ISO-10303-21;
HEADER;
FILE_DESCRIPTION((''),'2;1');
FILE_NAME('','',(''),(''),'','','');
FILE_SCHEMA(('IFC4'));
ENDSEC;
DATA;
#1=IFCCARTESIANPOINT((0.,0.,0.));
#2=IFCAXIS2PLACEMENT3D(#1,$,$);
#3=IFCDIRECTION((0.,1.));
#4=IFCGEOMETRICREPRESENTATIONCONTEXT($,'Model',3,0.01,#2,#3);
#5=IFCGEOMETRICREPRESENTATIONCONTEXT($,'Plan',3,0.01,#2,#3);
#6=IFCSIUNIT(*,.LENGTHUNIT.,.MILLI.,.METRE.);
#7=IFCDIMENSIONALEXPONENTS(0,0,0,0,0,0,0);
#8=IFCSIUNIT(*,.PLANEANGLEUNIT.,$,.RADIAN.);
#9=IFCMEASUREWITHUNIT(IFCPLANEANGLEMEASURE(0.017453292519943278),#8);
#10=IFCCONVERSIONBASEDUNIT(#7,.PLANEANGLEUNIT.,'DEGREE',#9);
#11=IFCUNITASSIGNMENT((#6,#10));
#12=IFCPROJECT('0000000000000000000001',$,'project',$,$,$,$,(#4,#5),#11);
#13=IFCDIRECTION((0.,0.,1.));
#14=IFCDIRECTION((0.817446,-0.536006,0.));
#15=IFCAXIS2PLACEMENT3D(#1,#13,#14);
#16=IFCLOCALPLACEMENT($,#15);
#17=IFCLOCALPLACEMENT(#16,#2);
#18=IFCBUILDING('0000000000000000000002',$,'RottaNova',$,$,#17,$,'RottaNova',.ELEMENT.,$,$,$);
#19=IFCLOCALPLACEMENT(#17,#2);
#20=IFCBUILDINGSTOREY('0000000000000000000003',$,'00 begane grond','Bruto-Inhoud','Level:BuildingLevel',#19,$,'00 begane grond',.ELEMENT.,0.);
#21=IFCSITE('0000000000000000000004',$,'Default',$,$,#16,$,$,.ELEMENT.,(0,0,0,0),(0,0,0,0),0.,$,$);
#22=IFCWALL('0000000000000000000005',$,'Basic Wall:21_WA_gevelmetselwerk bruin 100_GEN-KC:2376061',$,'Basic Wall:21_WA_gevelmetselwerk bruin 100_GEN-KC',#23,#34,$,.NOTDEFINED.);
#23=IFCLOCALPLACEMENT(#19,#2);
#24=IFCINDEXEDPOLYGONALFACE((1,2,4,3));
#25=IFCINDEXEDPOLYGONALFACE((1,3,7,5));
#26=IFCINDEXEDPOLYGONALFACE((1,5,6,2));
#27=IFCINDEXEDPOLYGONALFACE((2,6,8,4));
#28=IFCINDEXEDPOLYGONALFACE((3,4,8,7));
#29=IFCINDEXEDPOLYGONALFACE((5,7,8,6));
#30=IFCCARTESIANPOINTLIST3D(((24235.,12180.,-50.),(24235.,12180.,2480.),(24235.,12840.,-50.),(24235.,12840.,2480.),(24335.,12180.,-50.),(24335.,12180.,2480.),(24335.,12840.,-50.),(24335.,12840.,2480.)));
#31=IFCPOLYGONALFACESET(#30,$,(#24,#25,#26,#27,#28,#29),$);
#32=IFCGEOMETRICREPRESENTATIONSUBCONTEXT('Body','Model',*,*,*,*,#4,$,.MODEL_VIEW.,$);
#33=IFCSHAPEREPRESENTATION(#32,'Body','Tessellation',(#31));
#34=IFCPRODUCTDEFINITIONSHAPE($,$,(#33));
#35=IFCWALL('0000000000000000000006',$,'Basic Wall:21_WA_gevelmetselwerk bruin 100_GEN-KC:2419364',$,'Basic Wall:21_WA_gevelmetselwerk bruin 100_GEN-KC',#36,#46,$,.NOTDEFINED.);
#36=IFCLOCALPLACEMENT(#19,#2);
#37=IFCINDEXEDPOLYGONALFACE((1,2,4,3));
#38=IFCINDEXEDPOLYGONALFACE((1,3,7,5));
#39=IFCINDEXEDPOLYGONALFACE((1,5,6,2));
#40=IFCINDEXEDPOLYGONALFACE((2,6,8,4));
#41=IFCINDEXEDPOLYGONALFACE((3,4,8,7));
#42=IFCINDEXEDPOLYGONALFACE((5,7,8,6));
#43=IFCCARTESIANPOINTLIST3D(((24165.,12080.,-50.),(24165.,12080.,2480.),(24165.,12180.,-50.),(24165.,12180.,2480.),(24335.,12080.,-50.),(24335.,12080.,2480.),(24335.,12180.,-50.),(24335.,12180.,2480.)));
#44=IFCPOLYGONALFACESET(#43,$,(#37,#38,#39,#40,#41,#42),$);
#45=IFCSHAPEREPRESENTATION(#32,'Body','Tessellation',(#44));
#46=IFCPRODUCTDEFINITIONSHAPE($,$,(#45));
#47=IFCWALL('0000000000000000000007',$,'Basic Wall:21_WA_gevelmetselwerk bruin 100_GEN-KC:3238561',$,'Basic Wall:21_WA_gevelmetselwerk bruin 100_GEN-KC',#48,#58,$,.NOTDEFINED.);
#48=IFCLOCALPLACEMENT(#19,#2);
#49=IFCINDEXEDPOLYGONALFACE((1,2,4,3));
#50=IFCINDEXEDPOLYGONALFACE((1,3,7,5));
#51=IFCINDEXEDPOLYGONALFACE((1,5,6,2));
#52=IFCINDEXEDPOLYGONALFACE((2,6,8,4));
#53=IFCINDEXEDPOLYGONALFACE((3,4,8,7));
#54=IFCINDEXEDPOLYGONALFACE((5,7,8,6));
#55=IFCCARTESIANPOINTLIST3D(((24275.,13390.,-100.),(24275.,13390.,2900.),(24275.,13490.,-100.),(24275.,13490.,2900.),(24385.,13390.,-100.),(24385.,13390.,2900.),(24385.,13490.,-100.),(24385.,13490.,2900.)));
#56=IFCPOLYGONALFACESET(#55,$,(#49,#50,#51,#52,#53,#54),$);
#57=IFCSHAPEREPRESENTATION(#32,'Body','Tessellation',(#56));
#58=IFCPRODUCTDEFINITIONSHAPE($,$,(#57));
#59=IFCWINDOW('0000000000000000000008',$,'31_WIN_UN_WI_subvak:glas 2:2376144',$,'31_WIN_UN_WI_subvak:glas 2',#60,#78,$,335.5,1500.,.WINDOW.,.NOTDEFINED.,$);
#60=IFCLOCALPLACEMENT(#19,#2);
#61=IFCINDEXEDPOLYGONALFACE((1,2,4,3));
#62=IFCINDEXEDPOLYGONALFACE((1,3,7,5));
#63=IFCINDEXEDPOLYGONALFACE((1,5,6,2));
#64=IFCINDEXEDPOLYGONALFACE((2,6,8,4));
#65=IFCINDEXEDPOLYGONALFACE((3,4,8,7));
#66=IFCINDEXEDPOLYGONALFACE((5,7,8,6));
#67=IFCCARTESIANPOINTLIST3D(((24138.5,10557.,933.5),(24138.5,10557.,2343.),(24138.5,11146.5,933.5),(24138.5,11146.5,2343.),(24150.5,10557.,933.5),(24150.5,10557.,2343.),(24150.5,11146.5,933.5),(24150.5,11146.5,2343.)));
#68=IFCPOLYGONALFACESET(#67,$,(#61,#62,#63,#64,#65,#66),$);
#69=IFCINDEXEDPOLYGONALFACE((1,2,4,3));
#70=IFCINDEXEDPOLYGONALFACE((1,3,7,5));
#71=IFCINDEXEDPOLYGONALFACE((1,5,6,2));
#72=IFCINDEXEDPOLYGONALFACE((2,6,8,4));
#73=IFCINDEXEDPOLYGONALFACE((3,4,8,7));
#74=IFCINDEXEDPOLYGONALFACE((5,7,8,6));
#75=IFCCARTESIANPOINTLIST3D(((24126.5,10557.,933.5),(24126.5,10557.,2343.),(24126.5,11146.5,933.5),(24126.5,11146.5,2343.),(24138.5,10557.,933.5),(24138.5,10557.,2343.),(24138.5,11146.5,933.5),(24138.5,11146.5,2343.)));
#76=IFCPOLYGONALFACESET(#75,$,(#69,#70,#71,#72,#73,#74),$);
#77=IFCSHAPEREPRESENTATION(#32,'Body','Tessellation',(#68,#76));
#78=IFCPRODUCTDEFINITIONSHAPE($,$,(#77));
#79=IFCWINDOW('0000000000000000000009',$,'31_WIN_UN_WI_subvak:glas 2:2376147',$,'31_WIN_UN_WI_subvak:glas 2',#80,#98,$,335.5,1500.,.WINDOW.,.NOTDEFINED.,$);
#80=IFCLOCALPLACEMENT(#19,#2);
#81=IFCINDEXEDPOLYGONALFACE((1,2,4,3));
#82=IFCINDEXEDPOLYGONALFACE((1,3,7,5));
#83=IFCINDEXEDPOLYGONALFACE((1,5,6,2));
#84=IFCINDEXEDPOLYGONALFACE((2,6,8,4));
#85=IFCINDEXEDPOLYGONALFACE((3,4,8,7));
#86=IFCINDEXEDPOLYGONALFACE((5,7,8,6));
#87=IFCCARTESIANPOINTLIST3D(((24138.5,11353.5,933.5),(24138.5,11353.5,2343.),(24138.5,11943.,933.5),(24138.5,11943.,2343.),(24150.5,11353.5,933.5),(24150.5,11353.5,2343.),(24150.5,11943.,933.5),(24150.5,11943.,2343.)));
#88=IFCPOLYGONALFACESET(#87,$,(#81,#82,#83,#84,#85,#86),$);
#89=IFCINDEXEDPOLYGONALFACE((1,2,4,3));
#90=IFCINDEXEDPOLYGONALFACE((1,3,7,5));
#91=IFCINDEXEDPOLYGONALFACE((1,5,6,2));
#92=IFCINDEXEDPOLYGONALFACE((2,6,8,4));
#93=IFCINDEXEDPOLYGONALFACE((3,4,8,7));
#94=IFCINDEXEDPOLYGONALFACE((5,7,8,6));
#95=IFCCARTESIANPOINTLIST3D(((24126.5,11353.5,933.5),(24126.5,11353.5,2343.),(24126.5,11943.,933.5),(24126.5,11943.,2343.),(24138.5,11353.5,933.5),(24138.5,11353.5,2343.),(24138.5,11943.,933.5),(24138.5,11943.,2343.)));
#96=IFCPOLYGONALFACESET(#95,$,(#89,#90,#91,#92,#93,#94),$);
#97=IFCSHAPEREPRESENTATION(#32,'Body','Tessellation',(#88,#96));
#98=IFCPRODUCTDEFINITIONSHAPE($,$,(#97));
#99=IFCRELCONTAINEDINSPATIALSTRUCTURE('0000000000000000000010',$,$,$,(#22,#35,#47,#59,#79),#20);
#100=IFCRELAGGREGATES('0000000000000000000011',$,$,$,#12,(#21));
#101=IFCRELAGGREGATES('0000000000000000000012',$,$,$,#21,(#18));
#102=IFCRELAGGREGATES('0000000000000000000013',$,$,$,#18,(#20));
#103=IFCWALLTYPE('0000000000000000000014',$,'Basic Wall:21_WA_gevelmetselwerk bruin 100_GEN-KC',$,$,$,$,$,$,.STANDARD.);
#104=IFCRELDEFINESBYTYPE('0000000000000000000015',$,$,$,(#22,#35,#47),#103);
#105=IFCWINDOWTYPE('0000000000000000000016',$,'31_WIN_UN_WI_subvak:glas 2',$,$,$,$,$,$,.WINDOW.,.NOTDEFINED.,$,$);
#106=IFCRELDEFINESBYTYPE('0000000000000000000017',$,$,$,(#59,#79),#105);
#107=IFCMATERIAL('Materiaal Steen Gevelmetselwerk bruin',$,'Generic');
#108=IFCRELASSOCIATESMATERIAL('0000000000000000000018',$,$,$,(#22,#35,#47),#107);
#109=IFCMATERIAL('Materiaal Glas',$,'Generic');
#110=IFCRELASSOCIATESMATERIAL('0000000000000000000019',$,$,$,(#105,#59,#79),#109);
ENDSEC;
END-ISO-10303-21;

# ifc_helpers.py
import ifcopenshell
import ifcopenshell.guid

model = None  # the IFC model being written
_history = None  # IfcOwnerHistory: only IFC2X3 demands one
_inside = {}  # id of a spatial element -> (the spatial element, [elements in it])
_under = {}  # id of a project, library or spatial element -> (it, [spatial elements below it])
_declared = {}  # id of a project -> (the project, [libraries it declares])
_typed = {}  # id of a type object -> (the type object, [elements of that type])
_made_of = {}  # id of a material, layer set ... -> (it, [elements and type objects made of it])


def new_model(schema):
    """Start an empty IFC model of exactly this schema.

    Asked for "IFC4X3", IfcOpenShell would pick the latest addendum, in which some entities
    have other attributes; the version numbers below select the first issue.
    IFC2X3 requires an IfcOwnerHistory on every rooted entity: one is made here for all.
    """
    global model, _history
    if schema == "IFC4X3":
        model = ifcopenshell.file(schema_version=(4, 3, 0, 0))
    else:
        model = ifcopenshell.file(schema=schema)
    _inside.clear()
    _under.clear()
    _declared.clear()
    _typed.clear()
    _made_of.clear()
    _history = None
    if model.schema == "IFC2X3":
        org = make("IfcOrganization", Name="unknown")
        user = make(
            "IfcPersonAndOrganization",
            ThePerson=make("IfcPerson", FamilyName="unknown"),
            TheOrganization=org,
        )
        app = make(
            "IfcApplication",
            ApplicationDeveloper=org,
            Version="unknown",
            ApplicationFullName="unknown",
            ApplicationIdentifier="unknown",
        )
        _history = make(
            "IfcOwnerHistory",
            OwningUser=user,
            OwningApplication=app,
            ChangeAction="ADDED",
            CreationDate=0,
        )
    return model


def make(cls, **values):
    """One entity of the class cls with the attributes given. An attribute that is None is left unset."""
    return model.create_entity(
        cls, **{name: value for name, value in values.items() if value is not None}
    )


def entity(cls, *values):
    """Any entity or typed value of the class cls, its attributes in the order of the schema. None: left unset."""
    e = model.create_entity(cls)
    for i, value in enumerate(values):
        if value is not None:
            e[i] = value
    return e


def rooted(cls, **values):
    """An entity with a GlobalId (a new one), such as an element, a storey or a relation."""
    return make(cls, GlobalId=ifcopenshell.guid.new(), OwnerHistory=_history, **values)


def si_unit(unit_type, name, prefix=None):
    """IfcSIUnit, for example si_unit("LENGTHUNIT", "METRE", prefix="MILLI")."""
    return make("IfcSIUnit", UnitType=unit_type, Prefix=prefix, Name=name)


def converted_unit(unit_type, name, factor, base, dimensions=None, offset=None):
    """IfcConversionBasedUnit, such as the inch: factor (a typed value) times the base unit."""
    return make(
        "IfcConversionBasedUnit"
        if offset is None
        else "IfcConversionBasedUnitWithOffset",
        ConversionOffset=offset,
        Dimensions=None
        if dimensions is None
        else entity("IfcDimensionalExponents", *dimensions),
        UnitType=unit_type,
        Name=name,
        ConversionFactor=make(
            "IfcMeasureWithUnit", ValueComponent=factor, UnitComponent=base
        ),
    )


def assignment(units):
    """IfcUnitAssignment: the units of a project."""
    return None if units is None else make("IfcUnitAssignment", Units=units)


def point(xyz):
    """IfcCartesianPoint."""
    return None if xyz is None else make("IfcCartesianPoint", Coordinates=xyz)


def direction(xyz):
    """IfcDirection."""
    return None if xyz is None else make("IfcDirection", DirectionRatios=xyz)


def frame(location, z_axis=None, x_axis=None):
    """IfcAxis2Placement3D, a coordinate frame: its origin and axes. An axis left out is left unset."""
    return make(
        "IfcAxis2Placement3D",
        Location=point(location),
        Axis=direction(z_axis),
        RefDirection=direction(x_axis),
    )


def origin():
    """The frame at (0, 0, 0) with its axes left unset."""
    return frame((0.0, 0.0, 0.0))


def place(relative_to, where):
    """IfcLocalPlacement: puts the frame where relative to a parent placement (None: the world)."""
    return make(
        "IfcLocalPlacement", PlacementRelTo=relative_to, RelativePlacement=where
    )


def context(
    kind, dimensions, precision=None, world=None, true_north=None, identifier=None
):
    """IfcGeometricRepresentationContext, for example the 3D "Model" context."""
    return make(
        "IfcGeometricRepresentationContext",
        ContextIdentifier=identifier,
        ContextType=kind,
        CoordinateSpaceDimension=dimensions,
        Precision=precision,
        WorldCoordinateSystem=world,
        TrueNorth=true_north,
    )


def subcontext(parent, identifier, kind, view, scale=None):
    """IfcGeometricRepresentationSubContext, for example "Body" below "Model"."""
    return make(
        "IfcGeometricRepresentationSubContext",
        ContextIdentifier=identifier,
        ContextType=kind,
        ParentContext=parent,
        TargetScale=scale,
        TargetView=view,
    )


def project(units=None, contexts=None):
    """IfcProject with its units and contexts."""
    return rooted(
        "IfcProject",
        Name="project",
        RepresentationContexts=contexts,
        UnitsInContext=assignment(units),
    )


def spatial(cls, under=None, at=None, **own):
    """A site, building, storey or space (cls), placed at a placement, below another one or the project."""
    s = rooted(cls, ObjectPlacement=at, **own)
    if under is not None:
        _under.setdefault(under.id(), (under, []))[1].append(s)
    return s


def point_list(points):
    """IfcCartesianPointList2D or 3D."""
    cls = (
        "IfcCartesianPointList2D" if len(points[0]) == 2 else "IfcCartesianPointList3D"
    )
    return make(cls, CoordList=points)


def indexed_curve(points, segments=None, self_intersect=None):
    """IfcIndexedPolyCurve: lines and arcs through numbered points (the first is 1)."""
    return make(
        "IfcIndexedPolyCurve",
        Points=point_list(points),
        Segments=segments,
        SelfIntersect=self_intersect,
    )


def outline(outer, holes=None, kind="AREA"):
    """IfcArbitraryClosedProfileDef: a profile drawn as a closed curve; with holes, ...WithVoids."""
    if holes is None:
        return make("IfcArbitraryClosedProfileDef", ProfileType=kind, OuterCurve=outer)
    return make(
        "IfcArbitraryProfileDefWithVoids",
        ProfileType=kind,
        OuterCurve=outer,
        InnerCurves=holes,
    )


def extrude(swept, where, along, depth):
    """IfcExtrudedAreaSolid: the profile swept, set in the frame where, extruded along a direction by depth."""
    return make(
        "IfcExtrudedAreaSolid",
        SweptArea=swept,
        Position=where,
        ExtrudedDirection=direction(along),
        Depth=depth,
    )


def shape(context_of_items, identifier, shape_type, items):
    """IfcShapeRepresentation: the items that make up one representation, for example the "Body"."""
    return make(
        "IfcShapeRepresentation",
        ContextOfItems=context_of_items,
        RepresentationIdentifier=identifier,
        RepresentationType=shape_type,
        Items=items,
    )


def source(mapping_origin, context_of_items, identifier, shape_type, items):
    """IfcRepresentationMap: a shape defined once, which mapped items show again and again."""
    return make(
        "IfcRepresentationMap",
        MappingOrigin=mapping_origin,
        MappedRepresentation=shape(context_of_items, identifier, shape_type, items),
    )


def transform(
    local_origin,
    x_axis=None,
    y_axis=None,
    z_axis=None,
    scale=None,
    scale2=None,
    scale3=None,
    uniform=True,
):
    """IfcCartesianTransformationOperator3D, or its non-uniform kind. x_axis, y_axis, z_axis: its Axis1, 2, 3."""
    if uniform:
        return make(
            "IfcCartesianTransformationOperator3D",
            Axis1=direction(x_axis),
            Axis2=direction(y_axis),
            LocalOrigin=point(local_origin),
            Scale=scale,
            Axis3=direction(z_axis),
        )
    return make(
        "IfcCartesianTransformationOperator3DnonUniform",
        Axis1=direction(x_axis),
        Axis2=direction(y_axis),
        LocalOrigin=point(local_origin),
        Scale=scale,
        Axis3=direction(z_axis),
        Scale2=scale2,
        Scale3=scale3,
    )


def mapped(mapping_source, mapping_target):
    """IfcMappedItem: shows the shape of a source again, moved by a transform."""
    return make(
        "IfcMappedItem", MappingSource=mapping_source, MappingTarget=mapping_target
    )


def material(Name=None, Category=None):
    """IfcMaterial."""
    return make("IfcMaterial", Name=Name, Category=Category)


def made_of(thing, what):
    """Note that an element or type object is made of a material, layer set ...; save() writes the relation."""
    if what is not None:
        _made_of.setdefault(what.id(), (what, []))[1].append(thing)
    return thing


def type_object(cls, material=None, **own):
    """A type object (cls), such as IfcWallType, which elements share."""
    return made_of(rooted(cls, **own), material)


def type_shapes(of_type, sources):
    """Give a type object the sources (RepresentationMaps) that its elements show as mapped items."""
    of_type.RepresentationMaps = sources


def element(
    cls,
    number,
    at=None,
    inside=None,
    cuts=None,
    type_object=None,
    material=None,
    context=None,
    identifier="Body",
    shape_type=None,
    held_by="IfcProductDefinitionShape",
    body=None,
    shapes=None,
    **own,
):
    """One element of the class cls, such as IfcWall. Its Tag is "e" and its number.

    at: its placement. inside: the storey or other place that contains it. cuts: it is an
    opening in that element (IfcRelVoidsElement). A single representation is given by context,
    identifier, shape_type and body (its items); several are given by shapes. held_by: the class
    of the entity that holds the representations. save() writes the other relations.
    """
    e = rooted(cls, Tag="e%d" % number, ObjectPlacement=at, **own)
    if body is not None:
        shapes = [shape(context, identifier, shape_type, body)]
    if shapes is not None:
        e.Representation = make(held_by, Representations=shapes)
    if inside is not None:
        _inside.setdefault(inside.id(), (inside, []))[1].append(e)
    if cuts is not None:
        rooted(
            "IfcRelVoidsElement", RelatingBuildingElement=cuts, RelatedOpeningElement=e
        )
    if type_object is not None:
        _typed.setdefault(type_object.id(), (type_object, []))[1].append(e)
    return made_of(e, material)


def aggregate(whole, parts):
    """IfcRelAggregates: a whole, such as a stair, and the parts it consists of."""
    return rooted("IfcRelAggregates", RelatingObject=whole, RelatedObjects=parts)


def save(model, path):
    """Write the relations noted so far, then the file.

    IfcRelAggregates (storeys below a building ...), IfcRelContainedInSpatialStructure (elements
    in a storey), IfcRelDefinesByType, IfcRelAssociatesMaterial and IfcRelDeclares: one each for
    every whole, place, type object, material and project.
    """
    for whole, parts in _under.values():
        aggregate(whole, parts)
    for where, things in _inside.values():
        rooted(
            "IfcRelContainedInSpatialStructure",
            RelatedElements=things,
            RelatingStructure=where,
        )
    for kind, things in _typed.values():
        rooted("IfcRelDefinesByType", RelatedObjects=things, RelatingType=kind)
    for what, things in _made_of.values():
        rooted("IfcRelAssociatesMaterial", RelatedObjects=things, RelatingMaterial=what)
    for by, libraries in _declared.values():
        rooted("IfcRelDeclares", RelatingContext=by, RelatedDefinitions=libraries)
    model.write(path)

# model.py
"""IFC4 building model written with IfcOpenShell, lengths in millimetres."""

from ifc_helpers import new_model, entity, si_unit, converted_unit, direction, frame, origin, place, context, subcontext, project, spatial, indexed_curve, outline, extrude, source, transform, mapped, material, type_object, type_shapes, element, save


model = new_model("IFC4")

# Units and contexts
model_context = context("Model", 3, precision=0.01, world=origin(), true_north=direction((0.0, 1.0)))
plan_context = context("Plan", 3, precision=0.01, world=origin(), true_north=direction((0.0, 1.0)))
body_context = subcontext(model_context, "Body", "Model", "MODEL_VIEW")
ifc_project = project(units=[si_unit("LENGTHUNIT", "METRE", prefix="MILLI"), converted_unit("PLANEANGLEUNIT", "DEGREE", entity("IfcPlaneAngleMeasure", 0.017453292519943278), si_unit("PLANEANGLEUNIT", "RADIAN"), dimensions=[0, 0, 0, 0, 0, 0, 0])], contexts=[model_context, plan_context])

# Site, building, storey
site_placement = place(None, frame((0.0, 0.0, 0.0), z_axis=(0.0, 0.0, 1.0), x_axis=(0.817446, -0.536006, 0.0)))
site = spatial("IfcSite", under=ifc_project, at=site_placement, Name="Default", CompositionType="ELEMENT", RefLatitude=(0, 0, 0, 0), RefLongitude=(0, 0, 0, 0), RefElevation=0.0)
building_placement = place(site_placement, origin())
building = spatial("IfcBuilding", under=site, at=building_placement, Name="RottaNova", LongName="RottaNova", CompositionType="ELEMENT")
storey_placement = place(building_placement, origin())
storey = spatial("IfcBuildingStorey", under=building, at=storey_placement, Name="00 begane grond", Description="Bruto-Inhoud", ObjectType="Level:BuildingLevel", LongName="00 begane grond", CompositionType="ELEMENT", Elevation=0.0)

# Shared definitions
ifc_material_1 = material(Name="Materiaal Glas", Category="Generic")

# Walls
ifc_material_2 = material(Name="Materiaal Steen Gevelmetselwerk bruin", Category="Generic")
wall_type_1 = type_object("IfcWallType", Name="Basic Wall:21_WA_gevelmetselwerk bruin 100_GEN-KC", PredefinedType="STANDARD")
wall_1_placement = place(storey_placement, frame((24285.0, 12840.0, -50.0), z_axis=(0.0, 0.0, 1.0), x_axis=(0.0, -1.0, 0.0)))
element("IfcWall", 1, at=wall_1_placement, inside=storey, type_object=wall_type_1, material=ifc_material_2, Name="Basic Wall:21_WA_gevelmetselwerk bruin 100_GEN-KC:2376061", ObjectType="Basic Wall:21_WA_gevelmetselwerk bruin 100_GEN-KC", PredefinedType="NOTDEFINED", context=body_context, shape_type="SweptSolid", body=[
    extrude(outline(indexed_curve([(660.0, 50.0), (0.0, 50.0), (0.0, -50.0), (660.0, -50.0), (660.0, 50.0)], self_intersect=False)), origin(), (0.0, 0.0, 1.0), 2530.0),
])
wall_2_placement = place(storey_placement, frame((24335.0, 12130.0, -50.0), z_axis=(0.0, 0.0, 1.0), x_axis=(-1.0, 0.0, 0.0)))
element("IfcWall", 2, at=wall_2_placement, inside=storey, type_object=wall_type_1, material=ifc_material_2, Name="Basic Wall:21_WA_gevelmetselwerk bruin 100_GEN-KC:2419364", ObjectType="Basic Wall:21_WA_gevelmetselwerk bruin 100_GEN-KC", PredefinedType="NOTDEFINED", context=body_context, shape_type="SweptSolid", body=[
    extrude(outline(indexed_curve([(170.0, 50.0), (0.0, 50.0), (0.0, -50.0), (170.0, -50.0), (170.0, 50.0)], self_intersect=False)), origin(), (0.0, 0.0, 1.0), 2530.0),
])
wall_3_placement = place(storey_placement, frame((24385.0, 13440.0, -100.0), z_axis=(0.0, 0.0, 1.0), x_axis=(-1.0, 0.0, 0.0)))
element("IfcWall", 3, at=wall_3_placement, inside=storey, type_object=wall_type_1, material=ifc_material_2, Name="Basic Wall:21_WA_gevelmetselwerk bruin 100_GEN-KC:3238561", ObjectType="Basic Wall:21_WA_gevelmetselwerk bruin 100_GEN-KC", PredefinedType="NOTDEFINED", context=body_context, shape_type="SweptSolid", body=[
    extrude(outline(indexed_curve([(110.0, 50.0), (0.0, 50.0), (0.0, -50.0), (110.0, -50.0), (110.0, 50.0)], self_intersect=False)), origin(), (0.0, 0.0, 1.0), 3000.0),
])

# Windows
window_type = type_object("IfcWindowType", Name="31_WIN_UN_WI_subvak:glas 2", PartitioningType="NOTDEFINED", PredefinedType="WINDOW", material=ifc_material_1)
shared_shape_1 = source(origin(), body_context, "Body", "SweptSolid", [
    extrude(outline(indexed_curve([(-294.7, -6.0), (294.7, -6.0), (294.7, 6.0), (-294.7, 6.0), (-294.7, -6.0)], self_intersect=False)), frame((0.0, -6.0, 0.0)), (0.0, 0.0, 1.0), 1409.5),
    extrude(outline(indexed_curve([(-294.8, -6.0), (294.8, -6.0), (294.8, 6.0), (-294.8, 6.0), (-294.8, -6.0)], self_intersect=False)), frame((0.0, 6.0, 0.0)), (0.0, 0.0, 1.0), 1409.5),
])
type_shapes(window_type, [shared_shape_1])
for number, where, z_axis, x_axis, name in (
    (4, (24138.5, 10851.7, 933.5), (0.0, 0.0, 1.0), (0.0, 1.0, 0.0), "31_WIN_UN_WI_subvak:glas 2:2376144"),
    (5, (24138.5, 11648.2, 933.5), (0.0, 0.0, 1.0), (0.0, 1.0, 0.0), "31_WIN_UN_WI_subvak:glas 2:2376147"),
):
    element("IfcWindow", number, at=place(storey_placement, frame(where, z_axis=z_axis, x_axis=x_axis)), inside=storey, type_object=window_type, material=ifc_material_1, Name=name, ObjectType="31_WIN_UN_WI_subvak:glas 2", OverallHeight=335.5, OverallWidth=1500.0, PartitioningType="NOTDEFINED", PredefinedType="WINDOW", context=body_context, shape_type="MappedRepresentation", body=[
        mapped(shared_shape_1, transform((0.0, 0.0, 0.0), scale=1.0)),
    ])

save(model, "model.ifc")
